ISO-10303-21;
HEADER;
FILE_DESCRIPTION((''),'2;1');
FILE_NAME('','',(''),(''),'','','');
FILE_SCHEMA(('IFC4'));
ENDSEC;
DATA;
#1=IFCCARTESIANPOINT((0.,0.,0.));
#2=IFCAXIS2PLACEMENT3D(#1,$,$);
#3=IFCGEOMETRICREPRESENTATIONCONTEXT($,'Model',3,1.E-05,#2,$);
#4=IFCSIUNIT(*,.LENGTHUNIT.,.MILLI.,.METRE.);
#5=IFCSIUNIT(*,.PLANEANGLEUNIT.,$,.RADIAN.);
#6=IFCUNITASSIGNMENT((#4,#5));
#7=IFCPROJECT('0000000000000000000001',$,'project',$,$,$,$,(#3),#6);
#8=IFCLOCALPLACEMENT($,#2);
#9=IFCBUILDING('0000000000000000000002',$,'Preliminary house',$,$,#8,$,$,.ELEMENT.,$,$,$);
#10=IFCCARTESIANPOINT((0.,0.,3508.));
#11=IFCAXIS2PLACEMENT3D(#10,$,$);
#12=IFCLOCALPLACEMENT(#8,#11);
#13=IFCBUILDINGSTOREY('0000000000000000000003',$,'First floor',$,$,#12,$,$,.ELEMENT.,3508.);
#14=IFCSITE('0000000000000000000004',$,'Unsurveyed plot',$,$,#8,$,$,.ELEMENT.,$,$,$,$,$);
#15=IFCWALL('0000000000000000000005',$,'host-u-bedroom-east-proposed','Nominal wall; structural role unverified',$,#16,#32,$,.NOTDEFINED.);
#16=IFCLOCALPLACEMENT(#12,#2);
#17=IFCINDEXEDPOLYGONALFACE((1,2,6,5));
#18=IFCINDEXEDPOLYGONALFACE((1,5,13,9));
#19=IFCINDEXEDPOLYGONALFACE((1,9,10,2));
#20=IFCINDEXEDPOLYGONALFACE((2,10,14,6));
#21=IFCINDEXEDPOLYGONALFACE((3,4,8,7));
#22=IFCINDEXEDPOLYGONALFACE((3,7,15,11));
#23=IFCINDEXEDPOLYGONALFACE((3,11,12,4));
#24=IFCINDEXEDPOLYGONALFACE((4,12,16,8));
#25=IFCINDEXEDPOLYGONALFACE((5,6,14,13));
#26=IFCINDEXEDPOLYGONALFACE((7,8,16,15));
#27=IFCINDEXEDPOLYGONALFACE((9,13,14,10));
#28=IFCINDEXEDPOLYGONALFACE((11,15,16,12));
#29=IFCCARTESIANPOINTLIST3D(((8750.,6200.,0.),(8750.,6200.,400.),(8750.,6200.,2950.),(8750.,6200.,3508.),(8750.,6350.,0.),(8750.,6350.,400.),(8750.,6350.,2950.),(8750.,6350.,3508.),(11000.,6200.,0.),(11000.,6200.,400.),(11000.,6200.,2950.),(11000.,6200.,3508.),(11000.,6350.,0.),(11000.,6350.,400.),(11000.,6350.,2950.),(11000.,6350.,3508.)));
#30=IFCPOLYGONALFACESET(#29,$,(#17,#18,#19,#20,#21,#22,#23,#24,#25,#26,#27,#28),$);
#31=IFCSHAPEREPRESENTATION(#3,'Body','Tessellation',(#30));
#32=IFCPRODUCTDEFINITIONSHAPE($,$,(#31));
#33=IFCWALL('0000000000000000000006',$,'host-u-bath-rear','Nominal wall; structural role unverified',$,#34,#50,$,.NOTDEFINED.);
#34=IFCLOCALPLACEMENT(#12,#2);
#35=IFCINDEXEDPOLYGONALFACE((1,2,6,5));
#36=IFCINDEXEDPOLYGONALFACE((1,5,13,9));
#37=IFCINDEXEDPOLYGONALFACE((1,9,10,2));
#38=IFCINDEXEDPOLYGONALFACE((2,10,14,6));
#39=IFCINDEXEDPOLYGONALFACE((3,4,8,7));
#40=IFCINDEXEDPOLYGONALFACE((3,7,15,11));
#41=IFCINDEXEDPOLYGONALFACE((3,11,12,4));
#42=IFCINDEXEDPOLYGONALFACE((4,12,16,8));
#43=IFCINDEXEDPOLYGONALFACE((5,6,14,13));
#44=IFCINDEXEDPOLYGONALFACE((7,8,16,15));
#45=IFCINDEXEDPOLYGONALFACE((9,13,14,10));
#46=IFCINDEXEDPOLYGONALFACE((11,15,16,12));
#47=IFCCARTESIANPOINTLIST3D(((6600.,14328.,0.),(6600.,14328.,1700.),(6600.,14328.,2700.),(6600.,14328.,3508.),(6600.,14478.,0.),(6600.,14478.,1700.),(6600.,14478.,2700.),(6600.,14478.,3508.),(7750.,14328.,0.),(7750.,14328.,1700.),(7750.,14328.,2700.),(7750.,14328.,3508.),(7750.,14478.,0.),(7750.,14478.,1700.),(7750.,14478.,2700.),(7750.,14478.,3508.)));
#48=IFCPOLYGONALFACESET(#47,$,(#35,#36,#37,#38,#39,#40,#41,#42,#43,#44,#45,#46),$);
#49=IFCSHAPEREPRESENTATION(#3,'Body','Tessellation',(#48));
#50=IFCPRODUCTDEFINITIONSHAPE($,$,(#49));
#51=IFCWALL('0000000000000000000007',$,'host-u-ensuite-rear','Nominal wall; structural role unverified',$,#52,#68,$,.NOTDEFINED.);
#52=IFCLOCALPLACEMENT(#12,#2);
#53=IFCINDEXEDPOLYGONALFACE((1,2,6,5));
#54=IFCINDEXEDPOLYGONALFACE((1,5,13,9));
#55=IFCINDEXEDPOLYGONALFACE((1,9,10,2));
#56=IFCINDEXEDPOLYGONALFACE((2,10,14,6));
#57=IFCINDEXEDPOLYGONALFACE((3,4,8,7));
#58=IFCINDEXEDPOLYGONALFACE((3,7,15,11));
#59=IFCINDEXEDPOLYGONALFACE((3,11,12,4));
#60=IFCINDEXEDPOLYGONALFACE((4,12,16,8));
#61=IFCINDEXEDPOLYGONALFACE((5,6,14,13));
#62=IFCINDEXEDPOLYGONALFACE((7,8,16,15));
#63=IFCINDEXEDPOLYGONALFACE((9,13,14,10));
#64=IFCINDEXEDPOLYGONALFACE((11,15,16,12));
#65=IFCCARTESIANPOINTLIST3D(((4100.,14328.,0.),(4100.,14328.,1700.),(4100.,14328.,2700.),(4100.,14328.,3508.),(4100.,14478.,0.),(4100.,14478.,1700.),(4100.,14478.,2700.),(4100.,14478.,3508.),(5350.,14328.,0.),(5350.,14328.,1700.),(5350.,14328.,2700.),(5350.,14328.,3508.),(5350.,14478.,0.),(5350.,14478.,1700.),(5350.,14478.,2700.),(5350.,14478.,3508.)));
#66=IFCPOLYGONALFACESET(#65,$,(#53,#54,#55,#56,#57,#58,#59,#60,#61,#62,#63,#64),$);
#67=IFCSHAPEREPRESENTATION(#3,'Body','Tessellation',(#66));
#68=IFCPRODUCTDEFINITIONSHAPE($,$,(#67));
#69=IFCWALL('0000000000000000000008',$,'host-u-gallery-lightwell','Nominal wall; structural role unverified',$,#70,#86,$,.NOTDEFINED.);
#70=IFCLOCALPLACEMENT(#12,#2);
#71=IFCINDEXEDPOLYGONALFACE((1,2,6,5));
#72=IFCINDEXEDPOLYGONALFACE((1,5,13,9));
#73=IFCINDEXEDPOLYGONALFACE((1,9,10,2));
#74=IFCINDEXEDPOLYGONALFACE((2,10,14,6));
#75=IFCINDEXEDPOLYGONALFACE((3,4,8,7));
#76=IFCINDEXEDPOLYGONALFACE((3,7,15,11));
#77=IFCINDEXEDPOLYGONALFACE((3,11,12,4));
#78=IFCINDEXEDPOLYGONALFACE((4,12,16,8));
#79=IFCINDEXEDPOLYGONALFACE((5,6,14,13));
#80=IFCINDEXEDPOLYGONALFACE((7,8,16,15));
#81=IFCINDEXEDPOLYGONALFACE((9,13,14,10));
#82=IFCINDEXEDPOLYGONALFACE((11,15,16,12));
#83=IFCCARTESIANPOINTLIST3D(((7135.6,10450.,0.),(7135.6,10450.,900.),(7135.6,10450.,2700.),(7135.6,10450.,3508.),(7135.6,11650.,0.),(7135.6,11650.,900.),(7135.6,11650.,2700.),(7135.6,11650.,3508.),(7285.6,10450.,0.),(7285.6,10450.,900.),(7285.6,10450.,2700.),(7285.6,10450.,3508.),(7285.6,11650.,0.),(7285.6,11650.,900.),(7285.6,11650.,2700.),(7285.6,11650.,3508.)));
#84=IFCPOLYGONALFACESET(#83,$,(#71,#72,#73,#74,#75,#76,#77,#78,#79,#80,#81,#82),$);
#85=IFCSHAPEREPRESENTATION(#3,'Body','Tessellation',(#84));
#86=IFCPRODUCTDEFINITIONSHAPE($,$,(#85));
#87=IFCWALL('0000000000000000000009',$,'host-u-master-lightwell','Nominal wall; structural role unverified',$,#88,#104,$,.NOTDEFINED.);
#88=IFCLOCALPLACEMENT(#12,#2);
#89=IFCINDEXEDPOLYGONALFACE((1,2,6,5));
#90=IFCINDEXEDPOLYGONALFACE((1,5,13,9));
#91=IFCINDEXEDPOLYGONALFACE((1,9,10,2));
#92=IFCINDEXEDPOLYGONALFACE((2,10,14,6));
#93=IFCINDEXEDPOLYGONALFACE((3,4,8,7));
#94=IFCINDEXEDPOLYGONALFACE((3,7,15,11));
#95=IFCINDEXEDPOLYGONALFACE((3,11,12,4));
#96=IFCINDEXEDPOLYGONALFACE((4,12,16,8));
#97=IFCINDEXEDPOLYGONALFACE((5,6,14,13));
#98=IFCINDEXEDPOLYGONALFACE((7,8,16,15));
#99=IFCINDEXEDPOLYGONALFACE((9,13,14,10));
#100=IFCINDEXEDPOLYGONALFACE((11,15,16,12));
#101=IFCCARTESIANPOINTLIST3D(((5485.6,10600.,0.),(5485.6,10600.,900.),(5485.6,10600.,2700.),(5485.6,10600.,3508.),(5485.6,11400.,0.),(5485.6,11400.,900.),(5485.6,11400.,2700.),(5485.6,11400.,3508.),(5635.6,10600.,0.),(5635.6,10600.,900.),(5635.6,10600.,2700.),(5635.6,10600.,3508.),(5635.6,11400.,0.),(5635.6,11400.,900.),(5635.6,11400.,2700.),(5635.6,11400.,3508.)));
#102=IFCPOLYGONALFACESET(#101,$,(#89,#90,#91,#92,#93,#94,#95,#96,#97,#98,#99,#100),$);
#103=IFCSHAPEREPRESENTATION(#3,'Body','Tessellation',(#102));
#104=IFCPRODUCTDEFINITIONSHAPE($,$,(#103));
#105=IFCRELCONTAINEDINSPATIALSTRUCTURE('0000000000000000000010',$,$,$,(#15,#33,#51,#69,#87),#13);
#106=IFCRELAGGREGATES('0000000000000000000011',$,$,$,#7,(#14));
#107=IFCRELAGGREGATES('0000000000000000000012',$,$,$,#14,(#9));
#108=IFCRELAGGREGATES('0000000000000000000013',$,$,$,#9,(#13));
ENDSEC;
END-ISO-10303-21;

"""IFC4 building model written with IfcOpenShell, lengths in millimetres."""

from ifc_helpers import new_model, si_unit, frame, origin, place, context, project, spatial, polyline, outline, extrude, element, save


model = new_model("IFC4")

# Units and contexts
model_context = context("Model", 3, precision=1e-05, world=origin())
ifc_project = project(units=[si_unit("LENGTHUNIT", "METRE", prefix="MILLI"), si_unit("PLANEANGLEUNIT", "RADIAN")], contexts=[model_context])

# Site, building, storey
placement_1 = place(None, origin())
site = spatial("IfcSite", under=ifc_project, at=placement_1, Name="Unsurveyed plot", CompositionType="ELEMENT")
building = spatial("IfcBuilding", under=site, at=placement_1, Name="Preliminary house", CompositionType="ELEMENT")
placement_2 = place(placement_1, frame((0.0, 0.0, 3508.0)))
storey = spatial("IfcBuildingStorey", under=building, at=placement_2, Name="First floor", CompositionType="ELEMENT", Elevation=3508.0)

# Walls, openings
wall_1 = element("IfcWall", 1, at=placement_2, inside=storey, Name="host-u-bedroom-east-proposed", Description="Nominal wall; structural role unverified", PredefinedType="NOTDEFINED", context=model_context, shape_type="SweptSolid", body=[
    extrude(outline(polyline([(11000.0, 6350.0), (11000.0, 6200.0), (8750.0, 6200.0), (8750.0, 6350.0), (11000.0, 6350.0)])), origin(), (0.0, 0.0, 1.0), 3508.0),
])
element("IfcOpeningElement", 2, at=placement_2, cuts=wall_1, PredefinedType="OPENING", context=model_context, shape_type="SweptSolid", body=[
    extrude(outline(polyline([(8750.0, 5825.0), (11000.0, 5825.0), (11000.0, 6725.0), (8750.0, 6725.0), (8750.0, 5825.0)])), frame((0.0, 0.0, 400.0)), (0.0, 0.0, 1.0), 2550.0),
])
wall_2 = element("IfcWall", 3, at=placement_2, inside=storey, Name="host-u-bath-rear", Description="Nominal wall; structural role unverified", PredefinedType="NOTDEFINED", context=model_context, shape_type="SweptSolid", body=[
    extrude(outline(polyline([(7750.0, 14478.0), (7750.0, 14328.0), (6600.0, 14328.0), (6600.0, 14478.0), (7750.0, 14478.0)])), origin(), (0.0, 0.0, 1.0), 3508.0),
])
element("IfcOpeningElement", 4, at=placement_2, cuts=wall_2, PredefinedType="OPENING", context=model_context, shape_type="SweptSolid", body=[
    extrude(outline(polyline([(6600.0, 13953.0), (7750.0, 13953.0), (7750.0, 14853.0), (6600.0, 14853.0), (6600.0, 13953.0)])), frame((0.0, 0.0, 1700.0)), (0.0, 0.0, 1.0), 1000.0),
])
wall_3 = element("IfcWall", 5, at=placement_2, inside=storey, Name="host-u-ensuite-rear", Description="Nominal wall; structural role unverified", PredefinedType="NOTDEFINED", context=model_context, shape_type="SweptSolid", body=[
    extrude(outline(polyline([(5350.0, 14478.0), (5350.0, 14328.0), (4100.0, 14328.0), (4100.0, 14478.0), (5350.0, 14478.0)])), origin(), (0.0, 0.0, 1.0), 3508.0),
])
element("IfcOpeningElement", 6, at=placement_2, cuts=wall_3, PredefinedType="OPENING", context=model_context, shape_type="SweptSolid", body=[
    extrude(outline(polyline([(4100.0, 13953.0), (5350.0, 13953.0), (5350.0, 14853.0), (4100.0, 14853.0), (4100.0, 13953.0)])), frame((0.0, 0.0, 1700.0)), (0.0, 0.0, 1.0), 1000.0),
])
wall_4 = element("IfcWall", 7, at=placement_2, inside=storey, Name="host-u-gallery-lightwell", Description="Nominal wall; structural role unverified", PredefinedType="NOTDEFINED", context=model_context, shape_type="SweptSolid", body=[
    extrude(outline(polyline([(7135.6, 11650.0), (7285.6, 11650.0), (7285.6, 10450.0), (7135.6, 10450.0), (7135.6, 11650.0)])), origin(), (0.0, 0.0, 1.0), 3508.0),
])
element("IfcOpeningElement", 8, at=placement_2, cuts=wall_4, PredefinedType="OPENING", context=model_context, shape_type="SweptSolid", body=[
    extrude(outline(polyline([(7660.6, 10450.0), (7660.6, 11650.0), (6760.6, 11650.0), (6760.6, 10450.0), (7660.6, 10450.0)])), frame((0.0, 0.0, 900.0)), (0.0, 0.0, 1.0), 1800.0),
])
wall_5 = element("IfcWall", 9, at=placement_2, inside=storey, Name="host-u-master-lightwell", Description="Nominal wall; structural role unverified", PredefinedType="NOTDEFINED", context=model_context, shape_type="SweptSolid", body=[
    extrude(outline(polyline([(5485.6, 11400.0), (5635.6, 11400.0), (5635.6, 10600.0), (5485.6, 10600.0), (5485.6, 11400.0)])), origin(), (0.0, 0.0, 1.0), 3508.0),
])
element("IfcOpeningElement", 10, at=placement_2, cuts=wall_5, PredefinedType="OPENING", context=model_context, shape_type="SweptSolid", body=[
    extrude(outline(polyline([(6010.6, 10600.0), (6010.6, 11400.0), (5110.6, 11400.0), (5110.6, 10600.0), (6010.6, 10600.0)])), frame((0.0, 0.0, 900.0)), (0.0, 0.0, 1.0), 1800.0),
])

save(model, "model.ifc")
